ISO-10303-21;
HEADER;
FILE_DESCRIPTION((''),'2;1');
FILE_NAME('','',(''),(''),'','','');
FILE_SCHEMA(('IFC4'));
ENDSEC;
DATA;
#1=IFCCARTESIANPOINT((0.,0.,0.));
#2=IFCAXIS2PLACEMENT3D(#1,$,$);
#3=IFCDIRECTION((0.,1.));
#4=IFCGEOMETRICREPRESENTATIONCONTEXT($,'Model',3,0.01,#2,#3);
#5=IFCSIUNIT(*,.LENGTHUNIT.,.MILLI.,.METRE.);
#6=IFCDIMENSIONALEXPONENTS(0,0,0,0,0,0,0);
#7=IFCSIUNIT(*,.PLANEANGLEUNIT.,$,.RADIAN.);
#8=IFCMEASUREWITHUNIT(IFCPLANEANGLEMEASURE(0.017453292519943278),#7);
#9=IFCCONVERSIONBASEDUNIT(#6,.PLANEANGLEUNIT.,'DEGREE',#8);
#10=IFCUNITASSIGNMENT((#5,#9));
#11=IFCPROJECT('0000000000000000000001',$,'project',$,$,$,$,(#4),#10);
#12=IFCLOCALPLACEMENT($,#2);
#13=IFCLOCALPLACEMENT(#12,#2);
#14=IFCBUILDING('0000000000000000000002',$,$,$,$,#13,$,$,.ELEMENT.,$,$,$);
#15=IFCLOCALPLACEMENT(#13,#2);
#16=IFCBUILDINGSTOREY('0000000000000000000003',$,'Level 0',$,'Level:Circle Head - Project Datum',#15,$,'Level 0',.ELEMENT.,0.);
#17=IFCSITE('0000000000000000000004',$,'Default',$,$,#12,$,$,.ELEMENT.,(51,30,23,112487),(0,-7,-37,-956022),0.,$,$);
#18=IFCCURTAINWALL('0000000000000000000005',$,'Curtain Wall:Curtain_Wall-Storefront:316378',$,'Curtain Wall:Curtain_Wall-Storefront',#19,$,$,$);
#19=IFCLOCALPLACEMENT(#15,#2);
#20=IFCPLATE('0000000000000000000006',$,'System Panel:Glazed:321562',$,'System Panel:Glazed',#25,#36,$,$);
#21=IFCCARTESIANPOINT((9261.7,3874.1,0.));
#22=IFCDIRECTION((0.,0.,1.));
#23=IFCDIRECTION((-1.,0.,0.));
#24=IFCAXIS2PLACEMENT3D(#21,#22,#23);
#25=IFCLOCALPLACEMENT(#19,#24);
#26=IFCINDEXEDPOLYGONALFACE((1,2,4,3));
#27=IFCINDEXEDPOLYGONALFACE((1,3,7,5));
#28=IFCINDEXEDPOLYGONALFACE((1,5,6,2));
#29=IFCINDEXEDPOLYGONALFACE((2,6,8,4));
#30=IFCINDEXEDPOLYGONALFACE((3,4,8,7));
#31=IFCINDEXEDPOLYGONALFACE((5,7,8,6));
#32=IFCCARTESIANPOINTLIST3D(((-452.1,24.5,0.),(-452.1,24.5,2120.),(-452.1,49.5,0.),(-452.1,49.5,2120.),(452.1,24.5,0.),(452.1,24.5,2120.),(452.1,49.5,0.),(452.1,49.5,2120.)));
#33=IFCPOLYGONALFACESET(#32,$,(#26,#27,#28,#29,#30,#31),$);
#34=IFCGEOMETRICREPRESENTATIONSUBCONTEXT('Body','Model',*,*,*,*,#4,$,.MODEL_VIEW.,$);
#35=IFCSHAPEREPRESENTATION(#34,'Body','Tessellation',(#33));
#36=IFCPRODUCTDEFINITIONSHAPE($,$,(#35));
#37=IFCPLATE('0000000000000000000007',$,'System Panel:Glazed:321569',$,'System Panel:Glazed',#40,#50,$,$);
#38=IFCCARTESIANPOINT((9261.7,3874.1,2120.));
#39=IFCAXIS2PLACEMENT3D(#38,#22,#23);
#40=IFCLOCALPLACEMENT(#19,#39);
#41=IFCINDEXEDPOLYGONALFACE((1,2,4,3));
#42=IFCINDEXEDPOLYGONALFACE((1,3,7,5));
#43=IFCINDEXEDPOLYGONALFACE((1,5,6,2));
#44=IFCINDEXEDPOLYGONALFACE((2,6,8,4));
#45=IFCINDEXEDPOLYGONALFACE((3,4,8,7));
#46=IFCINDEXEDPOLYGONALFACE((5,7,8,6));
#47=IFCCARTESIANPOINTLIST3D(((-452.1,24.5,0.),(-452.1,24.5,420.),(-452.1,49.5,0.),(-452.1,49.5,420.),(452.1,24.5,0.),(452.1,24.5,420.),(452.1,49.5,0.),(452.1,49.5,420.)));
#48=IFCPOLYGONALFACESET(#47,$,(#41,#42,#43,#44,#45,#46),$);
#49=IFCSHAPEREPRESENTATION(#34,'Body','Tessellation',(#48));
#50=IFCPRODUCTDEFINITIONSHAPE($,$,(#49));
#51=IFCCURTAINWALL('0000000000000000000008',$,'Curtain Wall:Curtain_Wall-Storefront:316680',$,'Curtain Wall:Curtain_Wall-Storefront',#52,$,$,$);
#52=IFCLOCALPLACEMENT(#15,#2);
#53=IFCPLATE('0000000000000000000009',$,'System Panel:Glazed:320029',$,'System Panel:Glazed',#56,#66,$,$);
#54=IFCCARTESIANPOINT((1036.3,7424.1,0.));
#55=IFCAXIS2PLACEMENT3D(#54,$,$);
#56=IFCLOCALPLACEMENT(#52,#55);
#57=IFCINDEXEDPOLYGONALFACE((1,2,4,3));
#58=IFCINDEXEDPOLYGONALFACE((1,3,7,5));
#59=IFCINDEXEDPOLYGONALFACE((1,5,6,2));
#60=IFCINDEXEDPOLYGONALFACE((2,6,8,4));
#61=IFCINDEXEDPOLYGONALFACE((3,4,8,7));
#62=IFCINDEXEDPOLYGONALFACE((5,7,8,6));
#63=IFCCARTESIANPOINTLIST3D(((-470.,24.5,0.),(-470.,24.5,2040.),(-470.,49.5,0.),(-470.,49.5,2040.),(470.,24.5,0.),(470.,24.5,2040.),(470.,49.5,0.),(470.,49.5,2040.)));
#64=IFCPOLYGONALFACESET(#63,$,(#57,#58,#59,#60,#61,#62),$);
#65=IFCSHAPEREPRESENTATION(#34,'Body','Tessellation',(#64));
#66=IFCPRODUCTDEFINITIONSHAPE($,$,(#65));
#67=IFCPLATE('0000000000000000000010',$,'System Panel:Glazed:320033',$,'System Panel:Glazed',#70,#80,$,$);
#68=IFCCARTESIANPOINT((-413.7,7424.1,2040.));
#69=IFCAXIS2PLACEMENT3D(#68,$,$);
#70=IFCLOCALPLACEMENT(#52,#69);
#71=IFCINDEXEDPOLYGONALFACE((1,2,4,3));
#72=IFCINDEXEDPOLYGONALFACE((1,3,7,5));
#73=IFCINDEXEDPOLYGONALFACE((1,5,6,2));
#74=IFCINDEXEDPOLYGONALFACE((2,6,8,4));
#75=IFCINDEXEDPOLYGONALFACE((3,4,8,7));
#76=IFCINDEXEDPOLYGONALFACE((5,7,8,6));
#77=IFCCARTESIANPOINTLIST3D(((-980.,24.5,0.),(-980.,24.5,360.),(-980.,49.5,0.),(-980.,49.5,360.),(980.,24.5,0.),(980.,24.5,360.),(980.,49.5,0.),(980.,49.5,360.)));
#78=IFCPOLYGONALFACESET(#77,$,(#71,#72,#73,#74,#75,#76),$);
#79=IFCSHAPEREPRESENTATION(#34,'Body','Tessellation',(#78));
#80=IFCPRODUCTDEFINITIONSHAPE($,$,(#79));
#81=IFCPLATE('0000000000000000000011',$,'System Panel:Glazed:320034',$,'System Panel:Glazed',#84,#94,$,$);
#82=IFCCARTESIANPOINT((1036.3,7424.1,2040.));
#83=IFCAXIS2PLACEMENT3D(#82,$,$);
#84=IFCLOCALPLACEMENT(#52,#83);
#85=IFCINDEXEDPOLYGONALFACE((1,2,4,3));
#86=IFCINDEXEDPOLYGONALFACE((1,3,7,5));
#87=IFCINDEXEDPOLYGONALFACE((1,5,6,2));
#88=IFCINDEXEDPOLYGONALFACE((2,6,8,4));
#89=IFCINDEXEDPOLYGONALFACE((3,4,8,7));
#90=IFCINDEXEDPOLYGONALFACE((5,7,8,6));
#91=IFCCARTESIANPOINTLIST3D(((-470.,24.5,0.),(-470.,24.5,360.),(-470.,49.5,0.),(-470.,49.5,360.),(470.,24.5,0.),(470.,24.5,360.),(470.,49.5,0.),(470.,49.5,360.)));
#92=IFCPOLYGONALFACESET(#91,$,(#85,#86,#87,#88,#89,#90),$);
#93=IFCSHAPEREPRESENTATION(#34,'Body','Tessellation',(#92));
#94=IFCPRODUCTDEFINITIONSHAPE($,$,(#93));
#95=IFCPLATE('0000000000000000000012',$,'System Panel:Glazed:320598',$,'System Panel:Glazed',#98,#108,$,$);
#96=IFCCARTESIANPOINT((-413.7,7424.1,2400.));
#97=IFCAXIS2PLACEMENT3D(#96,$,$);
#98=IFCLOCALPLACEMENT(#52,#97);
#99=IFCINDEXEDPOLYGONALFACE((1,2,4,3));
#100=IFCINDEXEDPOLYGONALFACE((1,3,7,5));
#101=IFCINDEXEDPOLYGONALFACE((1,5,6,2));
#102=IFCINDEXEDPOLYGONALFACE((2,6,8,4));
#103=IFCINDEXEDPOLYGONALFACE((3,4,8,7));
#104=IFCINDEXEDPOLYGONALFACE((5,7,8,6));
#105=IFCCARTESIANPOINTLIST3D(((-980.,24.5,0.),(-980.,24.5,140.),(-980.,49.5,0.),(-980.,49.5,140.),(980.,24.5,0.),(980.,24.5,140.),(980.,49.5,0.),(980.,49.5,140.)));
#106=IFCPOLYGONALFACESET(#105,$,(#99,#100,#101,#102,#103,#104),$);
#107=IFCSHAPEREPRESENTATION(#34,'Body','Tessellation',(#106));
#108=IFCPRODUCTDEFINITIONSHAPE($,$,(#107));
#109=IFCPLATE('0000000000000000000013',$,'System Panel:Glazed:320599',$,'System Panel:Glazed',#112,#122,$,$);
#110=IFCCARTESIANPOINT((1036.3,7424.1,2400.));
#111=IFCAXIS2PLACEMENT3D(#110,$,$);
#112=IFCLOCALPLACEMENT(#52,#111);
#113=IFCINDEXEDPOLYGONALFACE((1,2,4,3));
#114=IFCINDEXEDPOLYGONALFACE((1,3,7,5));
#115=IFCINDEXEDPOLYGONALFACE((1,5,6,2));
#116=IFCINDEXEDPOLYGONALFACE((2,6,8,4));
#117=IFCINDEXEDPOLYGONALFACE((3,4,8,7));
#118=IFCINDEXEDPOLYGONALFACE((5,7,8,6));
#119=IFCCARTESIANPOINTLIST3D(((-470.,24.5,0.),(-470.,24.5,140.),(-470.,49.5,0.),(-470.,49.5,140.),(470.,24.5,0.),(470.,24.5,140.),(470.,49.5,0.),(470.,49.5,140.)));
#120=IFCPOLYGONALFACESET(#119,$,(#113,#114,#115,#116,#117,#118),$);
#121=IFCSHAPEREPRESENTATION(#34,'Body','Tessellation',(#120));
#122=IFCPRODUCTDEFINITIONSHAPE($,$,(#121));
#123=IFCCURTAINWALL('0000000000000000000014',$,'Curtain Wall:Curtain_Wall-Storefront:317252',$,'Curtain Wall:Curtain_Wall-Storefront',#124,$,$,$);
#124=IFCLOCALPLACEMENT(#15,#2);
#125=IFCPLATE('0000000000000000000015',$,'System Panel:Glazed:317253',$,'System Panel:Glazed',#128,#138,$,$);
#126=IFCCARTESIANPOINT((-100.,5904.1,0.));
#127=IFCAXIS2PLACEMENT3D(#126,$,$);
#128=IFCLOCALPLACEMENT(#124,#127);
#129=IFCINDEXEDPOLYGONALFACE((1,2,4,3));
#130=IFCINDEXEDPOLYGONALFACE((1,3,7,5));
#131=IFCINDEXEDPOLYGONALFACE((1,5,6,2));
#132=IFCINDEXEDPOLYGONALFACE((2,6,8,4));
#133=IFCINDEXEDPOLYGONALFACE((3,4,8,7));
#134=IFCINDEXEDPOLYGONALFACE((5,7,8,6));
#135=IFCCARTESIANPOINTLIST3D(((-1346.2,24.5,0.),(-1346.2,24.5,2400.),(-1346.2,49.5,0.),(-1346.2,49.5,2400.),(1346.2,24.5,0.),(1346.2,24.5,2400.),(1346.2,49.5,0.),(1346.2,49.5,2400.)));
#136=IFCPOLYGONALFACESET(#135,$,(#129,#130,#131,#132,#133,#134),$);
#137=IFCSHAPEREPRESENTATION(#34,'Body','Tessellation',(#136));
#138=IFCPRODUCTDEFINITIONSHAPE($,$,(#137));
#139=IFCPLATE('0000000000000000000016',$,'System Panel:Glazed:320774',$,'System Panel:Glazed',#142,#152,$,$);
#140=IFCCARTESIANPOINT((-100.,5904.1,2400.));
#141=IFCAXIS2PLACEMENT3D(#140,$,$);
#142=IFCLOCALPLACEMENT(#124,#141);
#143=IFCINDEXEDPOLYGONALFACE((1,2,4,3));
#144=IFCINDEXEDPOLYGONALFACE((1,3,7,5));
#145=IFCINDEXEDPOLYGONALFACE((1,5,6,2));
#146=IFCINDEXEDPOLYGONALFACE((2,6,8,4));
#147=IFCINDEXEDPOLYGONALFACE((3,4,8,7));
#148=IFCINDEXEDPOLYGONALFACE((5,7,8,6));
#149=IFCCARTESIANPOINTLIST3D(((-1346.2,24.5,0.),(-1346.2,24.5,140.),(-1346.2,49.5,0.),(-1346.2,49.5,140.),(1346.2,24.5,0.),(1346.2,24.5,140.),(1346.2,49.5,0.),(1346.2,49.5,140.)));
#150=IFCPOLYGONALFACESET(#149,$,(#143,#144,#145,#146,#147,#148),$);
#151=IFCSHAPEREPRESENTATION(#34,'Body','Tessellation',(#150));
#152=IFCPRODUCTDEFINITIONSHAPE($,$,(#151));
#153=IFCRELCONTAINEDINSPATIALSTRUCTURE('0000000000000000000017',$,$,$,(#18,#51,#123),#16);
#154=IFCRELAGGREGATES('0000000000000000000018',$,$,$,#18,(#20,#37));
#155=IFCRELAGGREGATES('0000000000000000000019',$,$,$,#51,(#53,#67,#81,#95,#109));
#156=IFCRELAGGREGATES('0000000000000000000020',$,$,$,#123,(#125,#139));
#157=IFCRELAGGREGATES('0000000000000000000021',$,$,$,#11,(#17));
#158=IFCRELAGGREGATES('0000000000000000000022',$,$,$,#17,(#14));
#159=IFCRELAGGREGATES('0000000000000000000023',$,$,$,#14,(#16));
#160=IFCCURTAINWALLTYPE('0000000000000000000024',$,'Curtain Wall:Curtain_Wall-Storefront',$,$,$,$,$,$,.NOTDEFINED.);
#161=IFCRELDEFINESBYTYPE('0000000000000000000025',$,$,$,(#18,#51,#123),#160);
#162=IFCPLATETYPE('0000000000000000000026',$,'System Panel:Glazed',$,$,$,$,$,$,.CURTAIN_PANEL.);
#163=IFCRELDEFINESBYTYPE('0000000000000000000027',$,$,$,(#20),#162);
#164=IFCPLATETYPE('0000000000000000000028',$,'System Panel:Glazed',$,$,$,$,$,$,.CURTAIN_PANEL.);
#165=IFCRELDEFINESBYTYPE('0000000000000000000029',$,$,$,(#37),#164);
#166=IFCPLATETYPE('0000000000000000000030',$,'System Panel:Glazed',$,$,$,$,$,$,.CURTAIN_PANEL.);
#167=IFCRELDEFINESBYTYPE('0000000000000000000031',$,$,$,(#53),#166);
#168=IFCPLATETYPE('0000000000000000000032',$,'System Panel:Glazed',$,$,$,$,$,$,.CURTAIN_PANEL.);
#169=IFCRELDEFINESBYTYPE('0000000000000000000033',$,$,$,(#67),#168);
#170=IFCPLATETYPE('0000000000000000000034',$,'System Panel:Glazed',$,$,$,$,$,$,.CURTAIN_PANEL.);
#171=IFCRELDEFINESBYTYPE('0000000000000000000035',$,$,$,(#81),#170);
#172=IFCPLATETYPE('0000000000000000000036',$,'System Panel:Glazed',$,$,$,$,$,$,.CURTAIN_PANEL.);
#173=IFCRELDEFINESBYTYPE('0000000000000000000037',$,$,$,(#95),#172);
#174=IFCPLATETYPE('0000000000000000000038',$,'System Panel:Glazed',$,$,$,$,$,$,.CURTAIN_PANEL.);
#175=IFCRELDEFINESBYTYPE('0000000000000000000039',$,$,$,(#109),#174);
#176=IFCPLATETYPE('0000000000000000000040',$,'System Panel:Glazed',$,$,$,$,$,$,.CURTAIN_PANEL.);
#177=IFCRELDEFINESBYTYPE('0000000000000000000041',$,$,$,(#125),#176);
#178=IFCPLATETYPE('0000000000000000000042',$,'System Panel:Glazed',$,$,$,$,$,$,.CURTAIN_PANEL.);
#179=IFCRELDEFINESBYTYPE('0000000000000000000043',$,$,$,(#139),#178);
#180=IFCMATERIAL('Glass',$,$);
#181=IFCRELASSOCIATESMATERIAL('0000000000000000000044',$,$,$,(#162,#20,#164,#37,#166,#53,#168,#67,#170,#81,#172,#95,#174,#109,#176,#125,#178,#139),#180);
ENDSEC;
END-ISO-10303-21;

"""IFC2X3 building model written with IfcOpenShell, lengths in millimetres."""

from ifc_helpers import new_model, entity, si_unit, converted_unit, direction, frame, origin, origin_2d_with_axis, place, context, subcontext, project, spatial, rectangle, extrude, source, transform, mapped, material, type_object, type_shapes, element, aggregate, save


model = new_model("IFC2X3")

# Units and contexts
model_context = context("Model", 3, precision=0.01, world=origin(), true_north=direction((0.0, 1.0)))
body_context = subcontext(model_context, "Body", "Model", "MODEL_VIEW")
ifc_project = project(units=[si_unit("LENGTHUNIT", "METRE", prefix="MILLI"), converted_unit("PLANEANGLEUNIT", "DEGREE", entity("IfcPlaneAngleMeasure", 0.017453292519943278), si_unit("PLANEANGLEUNIT", "RADIAN"), dimensions=[0, 0, 0, 0, 0, 0, 0])], contexts=[model_context])

# Site, building, storey
site_placement = place(None, origin())
site = spatial("IfcSite", under=ifc_project, at=site_placement, Name="Default", CompositionType="ELEMENT", RefLatitude=(51, 30, 23, 112487), RefLongitude=(0, -7, -37, -956022), RefElevation=0.0)
building_placement = place(site_placement, origin())
building = spatial("IfcBuilding", under=site, at=building_placement, CompositionType="ELEMENT")
storey_placement = place(building_placement, origin())
storey = spatial("IfcBuildingStorey", under=building, at=storey_placement, Name="Level 0", ObjectType="Level:Circle Head - Project Datum", LongName="Level 0", CompositionType="ELEMENT", Elevation=0.0)

# Curtain walls, plates
curtain_wall_type = type_object("IfcCurtainWallType", Name="Curtain Wall:Curtain_Wall-Storefront", PredefinedType="NOTDEFINED")
curtain_wall_1_placement = place(storey_placement, origin())
curtain_wall_1 = element("IfcCurtainWall", 1, at=curtain_wall_1_placement, inside=storey, type_object=curtain_wall_type, Name="Curtain Wall:Curtain_Wall-Storefront:316378", ObjectType="Curtain Wall:Curtain_Wall-Storefront")
ifc_material_1 = material(Name="Glass")
plate_type_1 = type_object("IfcPlateType", Name="System Panel:Glazed", PredefinedType="CURTAIN_PANEL", material=ifc_material_1)
shared_shape_1 = source(origin(), body_context, "Body", "SweptSolid", [
    extrude(rectangle(XDim=25.0, YDim=904.2, at=origin_2d_with_axis()), frame((0.0, 37.0, 0.0), z_axis=(0.0, 0.0, 1.0), x_axis=(0.0, 1.0, 0.0)), (0.0, 0.0, 1.0), 2120.0),
])
type_shapes(plate_type_1, [shared_shape_1])
plate_1_placement = place(curtain_wall_1_placement, frame((9261.7, 3874.1, 0.0), z_axis=(0.0, 0.0, 1.0), x_axis=(-1.0, 0.0, 0.0)))
plate_1 = element("IfcPlate", 2, at=plate_1_placement, type_object=plate_type_1, material=ifc_material_1, Name="System Panel:Glazed:321562", ObjectType="System Panel:Glazed", context=body_context, shape_type="MappedRepresentation", body=[
    mapped(shared_shape_1, transform((0.0, 0.0, 0.0), scale=1.0)),
])
plate_type_2 = type_object("IfcPlateType", Name="System Panel:Glazed", PredefinedType="CURTAIN_PANEL", material=ifc_material_1)
shared_shape_2 = source(origin(), body_context, "Body", "SweptSolid", [
    extrude(rectangle(XDim=25.0, YDim=904.2, at=origin_2d_with_axis()), frame((0.0, 37.0, 0.0), z_axis=(0.0, 0.0, 1.0), x_axis=(0.0, 1.0, 0.0)), (0.0, 0.0, 1.0), 420.0),
])
type_shapes(plate_type_2, [shared_shape_2])
plate_2_placement = place(curtain_wall_1_placement, frame((9261.7, 3874.1, 2120.0), z_axis=(0.0, 0.0, 1.0), x_axis=(-1.0, 0.0, 0.0)))
plate_2 = element("IfcPlate", 3, at=plate_2_placement, type_object=plate_type_2, material=ifc_material_1, Name="System Panel:Glazed:321569", ObjectType="System Panel:Glazed", context=body_context, shape_type="MappedRepresentation", body=[
    mapped(shared_shape_2, transform((0.0, 0.0, 0.0), scale=1.0)),
])
aggregate(curtain_wall_1, [plate_1, plate_2])
curtain_wall_2_placement = place(storey_placement, origin())
curtain_wall_2 = element("IfcCurtainWall", 4, at=curtain_wall_2_placement, inside=storey, type_object=curtain_wall_type, Name="Curtain Wall:Curtain_Wall-Storefront:316680", ObjectType="Curtain Wall:Curtain_Wall-Storefront")
plate_type_3 = type_object("IfcPlateType", Name="System Panel:Glazed", PredefinedType="CURTAIN_PANEL", material=ifc_material_1)
shared_shape_3 = source(origin(), body_context, "Body", "SweptSolid", [
    extrude(rectangle(XDim=25.0, YDim=940.0, at=origin_2d_with_axis()), frame((0.0, 37.0, 0.0), z_axis=(0.0, 0.0, 1.0), x_axis=(0.0, 1.0, 0.0)), (0.0, 0.0, 1.0), 2040.0),
])
type_shapes(plate_type_3, [shared_shape_3])
plate_3_placement = place(curtain_wall_2_placement, frame((1036.3, 7424.1, 0.0)))
plate_3 = element("IfcPlate", 5, at=plate_3_placement, type_object=plate_type_3, material=ifc_material_1, Name="System Panel:Glazed:320029", ObjectType="System Panel:Glazed", context=body_context, shape_type="MappedRepresentation", body=[
    mapped(shared_shape_3, transform((0.0, 0.0, 0.0), scale=1.0)),
])
plate_type_4 = type_object("IfcPlateType", Name="System Panel:Glazed", PredefinedType="CURTAIN_PANEL", material=ifc_material_1)
shared_shape_4 = source(origin(), body_context, "Body", "SweptSolid", [
    extrude(rectangle(XDim=25.0, YDim=1960.0, at=origin_2d_with_axis()), frame((0.0, 37.0, 0.0), z_axis=(0.0, 0.0, 1.0), x_axis=(0.0, 1.0, 0.0)), (0.0, 0.0, 1.0), 360.0),
])
type_shapes(plate_type_4, [shared_shape_4])
plate_4_placement = place(curtain_wall_2_placement, frame((-413.7, 7424.1, 2040.0)))
plate_4 = element("IfcPlate", 6, at=plate_4_placement, type_object=plate_type_4, material=ifc_material_1, Name="System Panel:Glazed:320033", ObjectType="System Panel:Glazed", context=body_context, shape_type="MappedRepresentation", body=[
    mapped(shared_shape_4, transform((0.0, 0.0, 0.0), scale=1.0)),
])
plate_type_5 = type_object("IfcPlateType", Name="System Panel:Glazed", PredefinedType="CURTAIN_PANEL", material=ifc_material_1)
shared_shape_5 = source(origin(), body_context, "Body", "SweptSolid", [
    extrude(rectangle(XDim=25.0, YDim=940.0, at=origin_2d_with_axis()), frame((0.0, 37.0, 0.0), z_axis=(0.0, 0.0, 1.0), x_axis=(0.0, 1.0, 0.0)), (0.0, 0.0, 1.0), 360.0),
])
type_shapes(plate_type_5, [shared_shape_5])
plate_5_placement = place(curtain_wall_2_placement, frame((1036.3, 7424.1, 2040.0)))
plate_5 = element("IfcPlate", 7, at=plate_5_placement, type_object=plate_type_5, material=ifc_material_1, Name="System Panel:Glazed:320034", ObjectType="System Panel:Glazed", context=body_context, shape_type="MappedRepresentation", body=[
    mapped(shared_shape_5, transform((0.0, 0.0, 0.0), scale=1.0)),
])
plate_type_6 = type_object("IfcPlateType", Name="System Panel:Glazed", PredefinedType="CURTAIN_PANEL", material=ifc_material_1)
shared_shape_6 = source(origin(), body_context, "Body", "SweptSolid", [
    extrude(rectangle(XDim=25.0, YDim=1960.0, at=origin_2d_with_axis()), frame((0.0, 37.0, 0.0), z_axis=(0.0, 0.0, 1.0), x_axis=(0.0, 1.0, 0.0)), (0.0, 0.0, 1.0), 140.0),
])
type_shapes(plate_type_6, [shared_shape_6])
plate_6_placement = place(curtain_wall_2_placement, frame((-413.7, 7424.1, 2400.0)))
plate_6 = element("IfcPlate", 8, at=plate_6_placement, type_object=plate_type_6, material=ifc_material_1, Name="System Panel:Glazed:320598", ObjectType="System Panel:Glazed", context=body_context, shape_type="MappedRepresentation", body=[
    mapped(shared_shape_6, transform((0.0, 0.0, 0.0), scale=1.0)),
])
plate_type_7 = type_object("IfcPlateType", Name="System Panel:Glazed", PredefinedType="CURTAIN_PANEL", material=ifc_material_1)
shared_shape_7 = source(origin(), body_context, "Body", "SweptSolid", [
    extrude(rectangle(XDim=25.0, YDim=940.0, at=origin_2d_with_axis()), frame((0.0, 37.0, 0.0), z_axis=(0.0, 0.0, 1.0), x_axis=(0.0, 1.0, 0.0)), (0.0, 0.0, 1.0), 140.0),
])
type_shapes(plate_type_7, [shared_shape_7])
plate_7_placement = place(curtain_wall_2_placement, frame((1036.3, 7424.1, 2400.0)))
plate_7 = element("IfcPlate", 9, at=plate_7_placement, type_object=plate_type_7, material=ifc_material_1, Name="System Panel:Glazed:320599", ObjectType="System Panel:Glazed", context=body_context, shape_type="MappedRepresentation", body=[
    mapped(shared_shape_7, transform((0.0, 0.0, 0.0), scale=1.0)),
])
aggregate(curtain_wall_2, [plate_3, plate_4, plate_5, plate_6, plate_7])
curtain_wall_3_placement = place(storey_placement, origin())
curtain_wall_3 = element("IfcCurtainWall", 10, at=curtain_wall_3_placement, inside=storey, type_object=curtain_wall_type, Name="Curtain Wall:Curtain_Wall-Storefront:317252", ObjectType="Curtain Wall:Curtain_Wall-Storefront")
plate_type_8 = type_object("IfcPlateType", Name="System Panel:Glazed", PredefinedType="CURTAIN_PANEL", material=ifc_material_1)
shared_shape_8 = source(origin(), body_context, "Body", "SweptSolid", [
    extrude(rectangle(XDim=25.0, YDim=2692.5, at=origin_2d_with_axis()), frame((0.0, 37.0, 0.0), z_axis=(0.0, 0.0, 1.0), x_axis=(0.0, 1.0, 0.0)), (0.0, 0.0, 1.0), 2400.0),
])
type_shapes(plate_type_8, [shared_shape_8])
plate_8_placement = place(curtain_wall_3_placement, frame((-100.0, 5904.1, 0.0)))
plate_8 = element("IfcPlate", 11, at=plate_8_placement, type_object=plate_type_8, material=ifc_material_1, Name="System Panel:Glazed:317253", ObjectType="System Panel:Glazed", context=body_context, shape_type="MappedRepresentation", body=[
    mapped(shared_shape_8, transform((0.0, 0.0, 0.0), scale=1.0)),
])
plate_type_9 = type_object("IfcPlateType", Name="System Panel:Glazed", PredefinedType="CURTAIN_PANEL", material=ifc_material_1)
shared_shape_9 = source(origin(), body_context, "Body", "SweptSolid", [
    extrude(rectangle(XDim=25.0, YDim=2692.5, at=origin_2d_with_axis()), frame((0.0, 37.0, 0.0), z_axis=(0.0, 0.0, 1.0), x_axis=(0.0, 1.0, 0.0)), (0.0, 0.0, 1.0), 140.0),
])
type_shapes(plate_type_9, [shared_shape_9])
plate_9_placement = place(curtain_wall_3_placement, frame((-100.0, 5904.1, 2400.0)))
plate_9 = element("IfcPlate", 12, at=plate_9_placement, type_object=plate_type_9, material=ifc_material_1, Name="System Panel:Glazed:320774", ObjectType="System Panel:Glazed", context=body_context, shape_type="MappedRepresentation", body=[
    mapped(shared_shape_9, transform((0.0, 0.0, 0.0), scale=1.0)),
])
aggregate(curtain_wall_3, [plate_8, plate_9])

save(model, "model.ifc")
